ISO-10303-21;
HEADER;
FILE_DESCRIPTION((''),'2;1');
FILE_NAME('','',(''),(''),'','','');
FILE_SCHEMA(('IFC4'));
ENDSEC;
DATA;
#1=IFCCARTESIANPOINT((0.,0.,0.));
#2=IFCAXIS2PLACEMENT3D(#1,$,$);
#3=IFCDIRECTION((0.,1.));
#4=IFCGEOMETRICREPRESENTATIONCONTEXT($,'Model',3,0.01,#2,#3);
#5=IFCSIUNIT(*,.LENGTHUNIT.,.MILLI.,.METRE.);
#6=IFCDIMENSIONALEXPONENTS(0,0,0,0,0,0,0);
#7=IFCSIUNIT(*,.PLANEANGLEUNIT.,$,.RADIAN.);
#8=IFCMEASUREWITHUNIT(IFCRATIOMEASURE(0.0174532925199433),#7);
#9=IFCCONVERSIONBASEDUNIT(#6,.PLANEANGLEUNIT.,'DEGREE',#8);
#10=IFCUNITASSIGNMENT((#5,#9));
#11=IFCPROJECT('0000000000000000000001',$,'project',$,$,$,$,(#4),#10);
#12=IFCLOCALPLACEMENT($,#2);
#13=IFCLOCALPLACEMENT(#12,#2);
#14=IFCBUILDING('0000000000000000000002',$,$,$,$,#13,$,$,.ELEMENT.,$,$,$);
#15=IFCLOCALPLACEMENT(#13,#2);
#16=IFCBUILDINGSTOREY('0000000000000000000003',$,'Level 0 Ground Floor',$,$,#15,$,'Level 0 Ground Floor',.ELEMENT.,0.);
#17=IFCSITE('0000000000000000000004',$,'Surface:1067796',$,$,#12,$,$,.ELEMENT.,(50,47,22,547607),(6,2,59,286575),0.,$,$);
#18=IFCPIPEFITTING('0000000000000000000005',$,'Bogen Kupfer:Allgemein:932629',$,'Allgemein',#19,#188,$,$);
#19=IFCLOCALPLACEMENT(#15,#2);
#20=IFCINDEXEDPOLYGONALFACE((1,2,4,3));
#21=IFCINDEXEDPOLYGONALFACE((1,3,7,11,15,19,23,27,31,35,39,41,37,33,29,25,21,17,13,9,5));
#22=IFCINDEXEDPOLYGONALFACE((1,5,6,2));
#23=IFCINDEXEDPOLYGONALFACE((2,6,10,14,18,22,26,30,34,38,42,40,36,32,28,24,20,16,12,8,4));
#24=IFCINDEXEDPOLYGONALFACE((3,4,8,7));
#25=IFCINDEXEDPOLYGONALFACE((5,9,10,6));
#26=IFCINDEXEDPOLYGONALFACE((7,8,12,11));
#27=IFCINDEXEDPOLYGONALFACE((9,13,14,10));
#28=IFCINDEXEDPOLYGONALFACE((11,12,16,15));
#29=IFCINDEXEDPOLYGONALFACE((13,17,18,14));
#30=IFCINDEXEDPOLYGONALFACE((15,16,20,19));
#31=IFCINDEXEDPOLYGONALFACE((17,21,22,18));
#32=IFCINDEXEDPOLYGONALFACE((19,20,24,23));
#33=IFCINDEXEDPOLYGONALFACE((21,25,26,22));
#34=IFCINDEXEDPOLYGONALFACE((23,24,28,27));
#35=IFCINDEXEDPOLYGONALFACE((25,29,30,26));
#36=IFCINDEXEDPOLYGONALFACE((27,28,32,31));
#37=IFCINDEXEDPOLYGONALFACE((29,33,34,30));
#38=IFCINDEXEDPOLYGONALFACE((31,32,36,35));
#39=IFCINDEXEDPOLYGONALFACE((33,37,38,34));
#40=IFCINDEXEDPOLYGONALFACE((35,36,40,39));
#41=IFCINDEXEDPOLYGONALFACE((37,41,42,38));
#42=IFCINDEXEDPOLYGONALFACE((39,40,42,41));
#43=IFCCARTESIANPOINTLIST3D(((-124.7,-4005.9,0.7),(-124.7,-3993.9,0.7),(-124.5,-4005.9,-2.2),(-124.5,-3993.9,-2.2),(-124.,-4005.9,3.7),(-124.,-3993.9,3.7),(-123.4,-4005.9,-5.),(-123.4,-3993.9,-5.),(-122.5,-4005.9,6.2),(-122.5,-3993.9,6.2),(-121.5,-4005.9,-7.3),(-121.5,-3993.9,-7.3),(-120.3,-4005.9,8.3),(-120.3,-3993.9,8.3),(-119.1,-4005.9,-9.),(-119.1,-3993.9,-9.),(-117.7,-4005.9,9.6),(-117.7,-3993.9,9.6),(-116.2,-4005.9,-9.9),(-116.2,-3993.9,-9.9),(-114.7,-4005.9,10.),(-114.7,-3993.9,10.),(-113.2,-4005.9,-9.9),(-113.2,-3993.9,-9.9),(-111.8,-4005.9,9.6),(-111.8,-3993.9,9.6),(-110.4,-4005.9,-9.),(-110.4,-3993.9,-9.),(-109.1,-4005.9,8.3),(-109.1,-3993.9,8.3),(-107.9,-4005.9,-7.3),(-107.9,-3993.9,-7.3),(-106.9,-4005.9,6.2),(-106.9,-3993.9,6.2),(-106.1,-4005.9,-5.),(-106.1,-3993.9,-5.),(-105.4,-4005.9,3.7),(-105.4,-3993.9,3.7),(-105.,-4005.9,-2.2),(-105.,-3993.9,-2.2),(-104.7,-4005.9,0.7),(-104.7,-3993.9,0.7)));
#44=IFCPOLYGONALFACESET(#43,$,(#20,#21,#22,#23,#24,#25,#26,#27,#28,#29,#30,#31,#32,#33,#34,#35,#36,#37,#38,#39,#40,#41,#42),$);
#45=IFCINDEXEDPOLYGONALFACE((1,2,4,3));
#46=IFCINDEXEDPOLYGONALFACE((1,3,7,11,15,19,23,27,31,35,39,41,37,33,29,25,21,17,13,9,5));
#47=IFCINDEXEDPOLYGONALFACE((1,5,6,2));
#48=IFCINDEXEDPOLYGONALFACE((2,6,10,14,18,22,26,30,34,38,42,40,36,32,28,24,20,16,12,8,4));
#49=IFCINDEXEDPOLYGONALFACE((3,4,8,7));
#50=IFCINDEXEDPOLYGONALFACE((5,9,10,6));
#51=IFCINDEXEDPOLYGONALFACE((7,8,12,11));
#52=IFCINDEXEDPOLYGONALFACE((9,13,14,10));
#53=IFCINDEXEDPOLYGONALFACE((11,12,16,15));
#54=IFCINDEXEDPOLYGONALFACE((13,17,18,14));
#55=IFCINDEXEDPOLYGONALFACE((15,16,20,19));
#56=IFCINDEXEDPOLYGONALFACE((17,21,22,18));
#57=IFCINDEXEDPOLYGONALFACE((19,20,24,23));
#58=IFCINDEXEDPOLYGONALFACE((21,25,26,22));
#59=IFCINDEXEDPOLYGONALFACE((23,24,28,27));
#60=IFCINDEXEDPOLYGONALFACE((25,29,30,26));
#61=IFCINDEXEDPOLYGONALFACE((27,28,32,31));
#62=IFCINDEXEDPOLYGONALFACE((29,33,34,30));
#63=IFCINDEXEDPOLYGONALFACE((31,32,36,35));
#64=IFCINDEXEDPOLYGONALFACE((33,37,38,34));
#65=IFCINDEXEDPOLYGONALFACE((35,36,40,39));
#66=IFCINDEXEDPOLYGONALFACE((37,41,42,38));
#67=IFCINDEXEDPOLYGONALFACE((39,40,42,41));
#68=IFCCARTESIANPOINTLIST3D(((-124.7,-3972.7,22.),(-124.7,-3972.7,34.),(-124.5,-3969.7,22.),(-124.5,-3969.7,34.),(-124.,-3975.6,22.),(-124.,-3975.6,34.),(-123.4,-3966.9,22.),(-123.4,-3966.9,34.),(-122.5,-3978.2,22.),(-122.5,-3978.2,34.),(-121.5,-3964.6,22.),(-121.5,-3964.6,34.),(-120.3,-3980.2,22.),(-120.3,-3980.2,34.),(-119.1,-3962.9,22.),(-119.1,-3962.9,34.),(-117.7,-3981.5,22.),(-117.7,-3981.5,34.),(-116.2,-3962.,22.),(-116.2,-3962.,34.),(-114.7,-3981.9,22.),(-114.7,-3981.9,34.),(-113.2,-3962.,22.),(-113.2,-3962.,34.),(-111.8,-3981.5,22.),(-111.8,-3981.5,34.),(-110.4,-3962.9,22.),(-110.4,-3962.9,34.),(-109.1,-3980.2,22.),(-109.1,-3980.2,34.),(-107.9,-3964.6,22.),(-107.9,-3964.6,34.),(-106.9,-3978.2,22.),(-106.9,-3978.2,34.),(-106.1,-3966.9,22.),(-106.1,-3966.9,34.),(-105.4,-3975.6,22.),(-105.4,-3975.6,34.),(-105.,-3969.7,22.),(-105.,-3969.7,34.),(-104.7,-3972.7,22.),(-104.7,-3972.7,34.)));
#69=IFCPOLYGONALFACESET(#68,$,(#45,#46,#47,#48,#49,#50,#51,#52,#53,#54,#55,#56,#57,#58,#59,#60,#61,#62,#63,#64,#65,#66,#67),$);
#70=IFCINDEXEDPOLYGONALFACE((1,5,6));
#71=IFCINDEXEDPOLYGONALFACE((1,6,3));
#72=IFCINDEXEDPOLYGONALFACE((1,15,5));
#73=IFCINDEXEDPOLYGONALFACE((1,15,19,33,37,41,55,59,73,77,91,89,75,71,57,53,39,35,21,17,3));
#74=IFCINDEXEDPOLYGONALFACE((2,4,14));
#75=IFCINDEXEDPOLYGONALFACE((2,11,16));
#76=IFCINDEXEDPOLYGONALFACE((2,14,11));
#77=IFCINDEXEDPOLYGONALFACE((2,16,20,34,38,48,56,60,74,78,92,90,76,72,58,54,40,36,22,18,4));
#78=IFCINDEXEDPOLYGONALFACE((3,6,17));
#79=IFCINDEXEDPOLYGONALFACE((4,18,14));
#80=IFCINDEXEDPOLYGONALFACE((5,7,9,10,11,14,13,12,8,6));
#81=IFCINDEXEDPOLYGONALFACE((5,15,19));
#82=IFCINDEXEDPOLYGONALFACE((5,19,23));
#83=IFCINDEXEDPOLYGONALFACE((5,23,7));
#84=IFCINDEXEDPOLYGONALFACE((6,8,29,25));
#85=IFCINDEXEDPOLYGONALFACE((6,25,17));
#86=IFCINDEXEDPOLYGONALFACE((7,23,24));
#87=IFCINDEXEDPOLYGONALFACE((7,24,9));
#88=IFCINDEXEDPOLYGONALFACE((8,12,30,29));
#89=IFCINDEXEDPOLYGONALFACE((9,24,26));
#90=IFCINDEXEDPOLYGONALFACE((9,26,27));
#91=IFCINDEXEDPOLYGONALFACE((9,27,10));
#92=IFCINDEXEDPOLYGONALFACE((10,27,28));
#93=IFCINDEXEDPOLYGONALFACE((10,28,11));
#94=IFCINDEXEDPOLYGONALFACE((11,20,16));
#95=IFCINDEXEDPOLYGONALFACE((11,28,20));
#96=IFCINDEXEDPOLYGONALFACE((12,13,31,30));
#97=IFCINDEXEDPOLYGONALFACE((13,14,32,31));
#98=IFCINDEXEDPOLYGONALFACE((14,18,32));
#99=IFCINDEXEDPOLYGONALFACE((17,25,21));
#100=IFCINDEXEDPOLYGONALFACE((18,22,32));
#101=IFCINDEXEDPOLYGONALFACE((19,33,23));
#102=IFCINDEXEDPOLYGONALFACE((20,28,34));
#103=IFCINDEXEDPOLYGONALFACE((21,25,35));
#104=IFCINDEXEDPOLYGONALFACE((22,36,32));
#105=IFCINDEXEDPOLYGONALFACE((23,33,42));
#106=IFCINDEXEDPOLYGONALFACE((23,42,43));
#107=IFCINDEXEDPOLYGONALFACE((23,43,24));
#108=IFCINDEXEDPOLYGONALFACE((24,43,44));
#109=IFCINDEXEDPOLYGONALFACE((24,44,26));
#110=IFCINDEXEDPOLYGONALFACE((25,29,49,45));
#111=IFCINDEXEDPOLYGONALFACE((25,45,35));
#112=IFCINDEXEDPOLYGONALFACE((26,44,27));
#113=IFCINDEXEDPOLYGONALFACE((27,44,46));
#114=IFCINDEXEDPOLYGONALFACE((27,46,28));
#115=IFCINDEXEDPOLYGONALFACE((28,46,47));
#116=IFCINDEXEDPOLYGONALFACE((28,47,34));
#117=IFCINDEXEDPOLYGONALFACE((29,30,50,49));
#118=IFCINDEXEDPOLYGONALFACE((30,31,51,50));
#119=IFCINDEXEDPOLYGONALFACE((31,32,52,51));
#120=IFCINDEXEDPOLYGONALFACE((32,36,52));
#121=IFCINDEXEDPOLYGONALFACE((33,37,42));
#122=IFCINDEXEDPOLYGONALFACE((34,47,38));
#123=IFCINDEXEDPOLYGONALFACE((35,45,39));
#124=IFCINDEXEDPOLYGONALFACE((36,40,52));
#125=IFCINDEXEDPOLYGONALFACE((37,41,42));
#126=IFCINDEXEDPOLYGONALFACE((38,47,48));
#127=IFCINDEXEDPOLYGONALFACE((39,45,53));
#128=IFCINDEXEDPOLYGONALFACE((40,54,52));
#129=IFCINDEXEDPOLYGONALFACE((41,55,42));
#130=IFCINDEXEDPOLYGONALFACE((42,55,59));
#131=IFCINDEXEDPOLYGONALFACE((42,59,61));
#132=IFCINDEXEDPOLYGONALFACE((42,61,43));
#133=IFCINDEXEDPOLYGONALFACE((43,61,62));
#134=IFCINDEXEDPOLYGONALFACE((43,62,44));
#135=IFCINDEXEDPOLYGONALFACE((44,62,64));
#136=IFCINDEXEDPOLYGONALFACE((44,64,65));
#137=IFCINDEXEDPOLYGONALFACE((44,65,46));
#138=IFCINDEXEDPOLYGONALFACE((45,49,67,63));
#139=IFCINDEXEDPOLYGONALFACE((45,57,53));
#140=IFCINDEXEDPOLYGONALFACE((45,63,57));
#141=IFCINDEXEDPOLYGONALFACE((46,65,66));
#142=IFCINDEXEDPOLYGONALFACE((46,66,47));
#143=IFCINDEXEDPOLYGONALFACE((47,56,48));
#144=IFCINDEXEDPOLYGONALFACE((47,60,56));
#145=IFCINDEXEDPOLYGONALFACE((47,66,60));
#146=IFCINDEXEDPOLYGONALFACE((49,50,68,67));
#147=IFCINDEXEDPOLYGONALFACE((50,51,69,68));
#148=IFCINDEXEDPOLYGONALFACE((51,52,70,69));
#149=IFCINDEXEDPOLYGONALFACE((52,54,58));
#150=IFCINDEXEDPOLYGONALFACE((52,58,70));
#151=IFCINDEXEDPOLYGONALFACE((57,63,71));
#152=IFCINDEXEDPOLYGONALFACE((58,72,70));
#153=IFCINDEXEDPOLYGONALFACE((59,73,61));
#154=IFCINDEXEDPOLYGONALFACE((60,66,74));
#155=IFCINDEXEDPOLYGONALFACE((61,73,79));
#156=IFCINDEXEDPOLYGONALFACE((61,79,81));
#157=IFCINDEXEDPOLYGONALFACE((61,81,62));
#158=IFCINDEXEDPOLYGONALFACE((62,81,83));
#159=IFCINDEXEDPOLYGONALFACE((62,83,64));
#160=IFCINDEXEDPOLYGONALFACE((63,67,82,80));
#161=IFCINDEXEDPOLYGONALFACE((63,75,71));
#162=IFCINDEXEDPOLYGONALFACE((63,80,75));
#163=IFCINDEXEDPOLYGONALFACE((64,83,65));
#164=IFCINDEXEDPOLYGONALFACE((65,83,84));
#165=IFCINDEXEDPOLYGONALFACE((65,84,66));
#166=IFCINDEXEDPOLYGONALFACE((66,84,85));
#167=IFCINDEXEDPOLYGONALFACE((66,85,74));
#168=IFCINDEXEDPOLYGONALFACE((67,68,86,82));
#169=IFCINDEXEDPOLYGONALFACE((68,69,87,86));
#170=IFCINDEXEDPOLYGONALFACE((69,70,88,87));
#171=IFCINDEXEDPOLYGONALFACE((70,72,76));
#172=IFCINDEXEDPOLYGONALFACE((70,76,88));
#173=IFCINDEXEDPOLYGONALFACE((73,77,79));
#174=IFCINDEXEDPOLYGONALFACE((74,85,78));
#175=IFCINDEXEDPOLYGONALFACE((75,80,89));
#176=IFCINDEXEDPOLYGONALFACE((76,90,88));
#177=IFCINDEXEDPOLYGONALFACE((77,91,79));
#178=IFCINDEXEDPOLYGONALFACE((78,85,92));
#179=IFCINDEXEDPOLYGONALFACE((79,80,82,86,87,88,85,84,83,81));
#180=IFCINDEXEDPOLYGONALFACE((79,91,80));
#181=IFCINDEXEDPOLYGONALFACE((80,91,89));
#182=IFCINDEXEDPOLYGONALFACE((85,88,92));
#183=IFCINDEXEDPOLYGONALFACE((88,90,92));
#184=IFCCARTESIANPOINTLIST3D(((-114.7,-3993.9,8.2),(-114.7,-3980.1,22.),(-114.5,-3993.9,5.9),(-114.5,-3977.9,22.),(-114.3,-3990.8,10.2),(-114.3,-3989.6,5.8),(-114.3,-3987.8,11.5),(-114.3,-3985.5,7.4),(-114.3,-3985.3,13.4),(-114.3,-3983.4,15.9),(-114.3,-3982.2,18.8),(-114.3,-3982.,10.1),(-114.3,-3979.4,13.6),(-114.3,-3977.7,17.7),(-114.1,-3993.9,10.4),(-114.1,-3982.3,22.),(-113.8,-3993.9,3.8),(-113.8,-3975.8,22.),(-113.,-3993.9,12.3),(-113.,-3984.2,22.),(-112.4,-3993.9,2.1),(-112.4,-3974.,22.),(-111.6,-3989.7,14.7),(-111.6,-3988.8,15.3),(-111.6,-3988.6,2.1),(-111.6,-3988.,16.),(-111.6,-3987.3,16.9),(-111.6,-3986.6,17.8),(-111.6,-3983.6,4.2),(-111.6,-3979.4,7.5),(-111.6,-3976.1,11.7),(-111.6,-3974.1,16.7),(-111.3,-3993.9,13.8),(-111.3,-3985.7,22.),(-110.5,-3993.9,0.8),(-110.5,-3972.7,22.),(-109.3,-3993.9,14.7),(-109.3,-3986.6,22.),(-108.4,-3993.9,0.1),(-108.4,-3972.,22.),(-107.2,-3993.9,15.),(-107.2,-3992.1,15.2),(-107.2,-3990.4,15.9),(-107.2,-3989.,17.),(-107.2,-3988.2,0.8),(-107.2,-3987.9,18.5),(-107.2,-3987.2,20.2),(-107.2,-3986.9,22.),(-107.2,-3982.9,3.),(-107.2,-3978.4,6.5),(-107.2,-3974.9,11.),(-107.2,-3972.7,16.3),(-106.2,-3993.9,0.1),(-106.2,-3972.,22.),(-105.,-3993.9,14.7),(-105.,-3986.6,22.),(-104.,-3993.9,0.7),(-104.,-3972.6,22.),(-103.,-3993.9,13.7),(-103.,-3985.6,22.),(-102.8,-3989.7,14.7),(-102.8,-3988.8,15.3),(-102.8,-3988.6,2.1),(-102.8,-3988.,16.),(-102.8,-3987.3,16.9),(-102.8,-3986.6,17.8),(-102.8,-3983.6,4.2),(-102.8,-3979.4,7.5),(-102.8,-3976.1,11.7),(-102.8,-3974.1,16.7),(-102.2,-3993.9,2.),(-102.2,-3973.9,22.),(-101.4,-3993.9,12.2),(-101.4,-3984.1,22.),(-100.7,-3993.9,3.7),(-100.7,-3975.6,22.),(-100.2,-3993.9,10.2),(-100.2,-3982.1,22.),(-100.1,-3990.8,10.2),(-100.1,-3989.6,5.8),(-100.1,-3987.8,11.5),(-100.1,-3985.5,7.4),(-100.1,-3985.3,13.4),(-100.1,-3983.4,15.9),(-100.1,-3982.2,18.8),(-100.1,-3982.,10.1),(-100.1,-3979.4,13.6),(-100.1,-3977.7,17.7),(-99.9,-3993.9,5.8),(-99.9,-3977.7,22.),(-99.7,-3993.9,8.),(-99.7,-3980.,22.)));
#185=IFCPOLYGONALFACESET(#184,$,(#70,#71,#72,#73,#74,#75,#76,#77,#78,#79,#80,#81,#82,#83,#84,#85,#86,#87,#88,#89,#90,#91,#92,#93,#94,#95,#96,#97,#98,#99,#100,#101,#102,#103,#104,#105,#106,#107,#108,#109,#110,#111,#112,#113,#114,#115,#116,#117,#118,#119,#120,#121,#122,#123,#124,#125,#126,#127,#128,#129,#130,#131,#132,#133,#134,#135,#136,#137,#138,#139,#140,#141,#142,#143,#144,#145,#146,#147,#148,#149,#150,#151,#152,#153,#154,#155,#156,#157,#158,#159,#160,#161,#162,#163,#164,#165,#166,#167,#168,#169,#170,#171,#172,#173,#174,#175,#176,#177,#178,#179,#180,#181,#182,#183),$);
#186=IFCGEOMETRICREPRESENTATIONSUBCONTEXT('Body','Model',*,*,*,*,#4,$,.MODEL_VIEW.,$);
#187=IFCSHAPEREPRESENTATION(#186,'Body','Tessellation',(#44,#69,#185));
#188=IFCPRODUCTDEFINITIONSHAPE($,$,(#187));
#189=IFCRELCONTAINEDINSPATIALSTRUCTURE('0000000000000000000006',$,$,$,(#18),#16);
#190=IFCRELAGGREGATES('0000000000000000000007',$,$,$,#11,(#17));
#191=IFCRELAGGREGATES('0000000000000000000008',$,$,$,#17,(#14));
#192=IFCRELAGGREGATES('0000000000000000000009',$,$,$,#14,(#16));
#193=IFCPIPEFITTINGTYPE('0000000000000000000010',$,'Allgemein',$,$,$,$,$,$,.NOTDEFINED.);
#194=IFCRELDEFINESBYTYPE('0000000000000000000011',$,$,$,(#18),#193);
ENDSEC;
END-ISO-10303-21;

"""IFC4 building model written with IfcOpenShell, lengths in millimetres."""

from ifc_helpers import new_model, entity, si_unit, converted_unit, direction, frame, frame_2d, origin, place, context, subcontext, project, spatial, circle, extrude, source, transform, mapped, type_object, type_shapes, element, save


model = new_model("IFC4")

# Units and contexts
model_context = context("Model", 3, precision=0.01, world=origin(), true_north=direction((0.0, 1.0)))
body_context = subcontext(model_context, "Body", "Model", "MODEL_VIEW")
ifc_project = project(units=[si_unit("LENGTHUNIT", "METRE", prefix="MILLI"), converted_unit("PLANEANGLEUNIT", "DEGREE", entity("IfcRatioMeasure", 0.0174532925199433), si_unit("PLANEANGLEUNIT", "RADIAN"), dimensions=[0, 0, 0, 0, 0, 0, 0])], contexts=[model_context])

# Site, building, storey
site_placement = place(None, origin())
site = spatial("IfcSite", under=ifc_project, at=site_placement, Name="Surface:1067796", CompositionType="ELEMENT", RefLatitude=(50, 47, 22, 547607), RefLongitude=(6, 2, 59, 286575), RefElevation=0.0)
building_placement = place(site_placement, origin())
building = spatial("IfcBuilding", under=site, at=building_placement, CompositionType="ELEMENT")
storey_placement = place(building_placement, origin())
storey = spatial("IfcBuildingStorey", under=building, at=storey_placement, Name="Level 0 Ground Floor", LongName="Level 0 Ground Floor", CompositionType="ELEMENT", Elevation=0.0)

# Pipe fitting
pipe_fitting_type_1 = type_object("IfcPipeFittingType", Name="Allgemein", PredefinedType="NOTDEFINED")
ifc_direction = entity("IfcDirection", [0.0, 0.0, -1.0])
trimmed_curve = entity("IfcTrimmedCurve", entity("IfcCircle", entity("IfcAxis2Placement2D", entity("IfcCartesianPoint", [-14.5, 0.0]), entity("IfcDirection", [0.0, 1.0])), 14.5), [entity("IfcParameterValue", 270.0)], [entity("IfcParameterValue", 0.0)], True, "PARAMETER")
shared_shape_1 = source(origin(), body_context, "Body", "SolidModel", [
    extrude(circle(Radius=10.0, at=frame_2d((0.0, 0.0), x_axis=(1.0, 0.0))), frame((0.0, 22.0, 0.0), z_axis=(0.0, 1.0, 0.0), x_axis=(-1.0, 0.0, 0.0)), (0.0, 0.0, 1.0), 12.0),
    extrude(circle(Radius=10.0, at=frame_2d((0.0, 0.0), x_axis=(1.0, 0.0))), frame((-34.0, 0.0, 0.0), z_axis=(1.0, 0.0, 0.0), x_axis=(0.0, 1.0, 0.0)), (0.0, 0.0, 1.0), 12.0),
    entity("IfcSurfaceCurveSweptAreaSolid", entity("IfcCircleProfileDef", "AREA", None, entity("IfcAxis2Placement2D", entity("IfcCartesianPoint", [0.0, 7.5]), entity("IfcDirection", [1.0, 0.0])), 7.5), entity("IfcAxis2Placement3D", entity("IfcCartesianPoint", [-7.5, 22.0, 0.0]), ifc_direction, entity("IfcDirection", [1.0, 0.0, 0.0])), trimmed_curve, 0.0, 90.0, entity("IfcSurfaceOfLinearExtrusion", entity("IfcArbitraryOpenProfileDef", "CURVE", None, trimmed_curve), entity("IfcAxis2Placement3D", entity("IfcCartesianPoint", [0.0, 0.0, -304.8])), ifc_direction, 1.0)),
])
type_shapes(pipe_fitting_type_1, [shared_shape_1])
for number, where, z_axis, x_axis, name in (
    (1, (-114.7, -3971.9, 0.0), (-1.0, 0.0, 0.0), (0.0, 0.0, -1.0), "Bogen Kupfer:Allgemein:932629"),
):
    element("IfcPipeFitting", number, at=place(storey_placement, frame(where, z_axis=z_axis, x_axis=x_axis)), inside=storey, type_object=pipe_fitting_type_1, Name=name, ObjectType="Allgemein", context=body_context, shape_type="MappedRepresentation", body=[
        mapped(shared_shape_1, transform((0.0, 0.0, 0.0), scale=1.0)),
    ])

save(model, "model.ifc")
